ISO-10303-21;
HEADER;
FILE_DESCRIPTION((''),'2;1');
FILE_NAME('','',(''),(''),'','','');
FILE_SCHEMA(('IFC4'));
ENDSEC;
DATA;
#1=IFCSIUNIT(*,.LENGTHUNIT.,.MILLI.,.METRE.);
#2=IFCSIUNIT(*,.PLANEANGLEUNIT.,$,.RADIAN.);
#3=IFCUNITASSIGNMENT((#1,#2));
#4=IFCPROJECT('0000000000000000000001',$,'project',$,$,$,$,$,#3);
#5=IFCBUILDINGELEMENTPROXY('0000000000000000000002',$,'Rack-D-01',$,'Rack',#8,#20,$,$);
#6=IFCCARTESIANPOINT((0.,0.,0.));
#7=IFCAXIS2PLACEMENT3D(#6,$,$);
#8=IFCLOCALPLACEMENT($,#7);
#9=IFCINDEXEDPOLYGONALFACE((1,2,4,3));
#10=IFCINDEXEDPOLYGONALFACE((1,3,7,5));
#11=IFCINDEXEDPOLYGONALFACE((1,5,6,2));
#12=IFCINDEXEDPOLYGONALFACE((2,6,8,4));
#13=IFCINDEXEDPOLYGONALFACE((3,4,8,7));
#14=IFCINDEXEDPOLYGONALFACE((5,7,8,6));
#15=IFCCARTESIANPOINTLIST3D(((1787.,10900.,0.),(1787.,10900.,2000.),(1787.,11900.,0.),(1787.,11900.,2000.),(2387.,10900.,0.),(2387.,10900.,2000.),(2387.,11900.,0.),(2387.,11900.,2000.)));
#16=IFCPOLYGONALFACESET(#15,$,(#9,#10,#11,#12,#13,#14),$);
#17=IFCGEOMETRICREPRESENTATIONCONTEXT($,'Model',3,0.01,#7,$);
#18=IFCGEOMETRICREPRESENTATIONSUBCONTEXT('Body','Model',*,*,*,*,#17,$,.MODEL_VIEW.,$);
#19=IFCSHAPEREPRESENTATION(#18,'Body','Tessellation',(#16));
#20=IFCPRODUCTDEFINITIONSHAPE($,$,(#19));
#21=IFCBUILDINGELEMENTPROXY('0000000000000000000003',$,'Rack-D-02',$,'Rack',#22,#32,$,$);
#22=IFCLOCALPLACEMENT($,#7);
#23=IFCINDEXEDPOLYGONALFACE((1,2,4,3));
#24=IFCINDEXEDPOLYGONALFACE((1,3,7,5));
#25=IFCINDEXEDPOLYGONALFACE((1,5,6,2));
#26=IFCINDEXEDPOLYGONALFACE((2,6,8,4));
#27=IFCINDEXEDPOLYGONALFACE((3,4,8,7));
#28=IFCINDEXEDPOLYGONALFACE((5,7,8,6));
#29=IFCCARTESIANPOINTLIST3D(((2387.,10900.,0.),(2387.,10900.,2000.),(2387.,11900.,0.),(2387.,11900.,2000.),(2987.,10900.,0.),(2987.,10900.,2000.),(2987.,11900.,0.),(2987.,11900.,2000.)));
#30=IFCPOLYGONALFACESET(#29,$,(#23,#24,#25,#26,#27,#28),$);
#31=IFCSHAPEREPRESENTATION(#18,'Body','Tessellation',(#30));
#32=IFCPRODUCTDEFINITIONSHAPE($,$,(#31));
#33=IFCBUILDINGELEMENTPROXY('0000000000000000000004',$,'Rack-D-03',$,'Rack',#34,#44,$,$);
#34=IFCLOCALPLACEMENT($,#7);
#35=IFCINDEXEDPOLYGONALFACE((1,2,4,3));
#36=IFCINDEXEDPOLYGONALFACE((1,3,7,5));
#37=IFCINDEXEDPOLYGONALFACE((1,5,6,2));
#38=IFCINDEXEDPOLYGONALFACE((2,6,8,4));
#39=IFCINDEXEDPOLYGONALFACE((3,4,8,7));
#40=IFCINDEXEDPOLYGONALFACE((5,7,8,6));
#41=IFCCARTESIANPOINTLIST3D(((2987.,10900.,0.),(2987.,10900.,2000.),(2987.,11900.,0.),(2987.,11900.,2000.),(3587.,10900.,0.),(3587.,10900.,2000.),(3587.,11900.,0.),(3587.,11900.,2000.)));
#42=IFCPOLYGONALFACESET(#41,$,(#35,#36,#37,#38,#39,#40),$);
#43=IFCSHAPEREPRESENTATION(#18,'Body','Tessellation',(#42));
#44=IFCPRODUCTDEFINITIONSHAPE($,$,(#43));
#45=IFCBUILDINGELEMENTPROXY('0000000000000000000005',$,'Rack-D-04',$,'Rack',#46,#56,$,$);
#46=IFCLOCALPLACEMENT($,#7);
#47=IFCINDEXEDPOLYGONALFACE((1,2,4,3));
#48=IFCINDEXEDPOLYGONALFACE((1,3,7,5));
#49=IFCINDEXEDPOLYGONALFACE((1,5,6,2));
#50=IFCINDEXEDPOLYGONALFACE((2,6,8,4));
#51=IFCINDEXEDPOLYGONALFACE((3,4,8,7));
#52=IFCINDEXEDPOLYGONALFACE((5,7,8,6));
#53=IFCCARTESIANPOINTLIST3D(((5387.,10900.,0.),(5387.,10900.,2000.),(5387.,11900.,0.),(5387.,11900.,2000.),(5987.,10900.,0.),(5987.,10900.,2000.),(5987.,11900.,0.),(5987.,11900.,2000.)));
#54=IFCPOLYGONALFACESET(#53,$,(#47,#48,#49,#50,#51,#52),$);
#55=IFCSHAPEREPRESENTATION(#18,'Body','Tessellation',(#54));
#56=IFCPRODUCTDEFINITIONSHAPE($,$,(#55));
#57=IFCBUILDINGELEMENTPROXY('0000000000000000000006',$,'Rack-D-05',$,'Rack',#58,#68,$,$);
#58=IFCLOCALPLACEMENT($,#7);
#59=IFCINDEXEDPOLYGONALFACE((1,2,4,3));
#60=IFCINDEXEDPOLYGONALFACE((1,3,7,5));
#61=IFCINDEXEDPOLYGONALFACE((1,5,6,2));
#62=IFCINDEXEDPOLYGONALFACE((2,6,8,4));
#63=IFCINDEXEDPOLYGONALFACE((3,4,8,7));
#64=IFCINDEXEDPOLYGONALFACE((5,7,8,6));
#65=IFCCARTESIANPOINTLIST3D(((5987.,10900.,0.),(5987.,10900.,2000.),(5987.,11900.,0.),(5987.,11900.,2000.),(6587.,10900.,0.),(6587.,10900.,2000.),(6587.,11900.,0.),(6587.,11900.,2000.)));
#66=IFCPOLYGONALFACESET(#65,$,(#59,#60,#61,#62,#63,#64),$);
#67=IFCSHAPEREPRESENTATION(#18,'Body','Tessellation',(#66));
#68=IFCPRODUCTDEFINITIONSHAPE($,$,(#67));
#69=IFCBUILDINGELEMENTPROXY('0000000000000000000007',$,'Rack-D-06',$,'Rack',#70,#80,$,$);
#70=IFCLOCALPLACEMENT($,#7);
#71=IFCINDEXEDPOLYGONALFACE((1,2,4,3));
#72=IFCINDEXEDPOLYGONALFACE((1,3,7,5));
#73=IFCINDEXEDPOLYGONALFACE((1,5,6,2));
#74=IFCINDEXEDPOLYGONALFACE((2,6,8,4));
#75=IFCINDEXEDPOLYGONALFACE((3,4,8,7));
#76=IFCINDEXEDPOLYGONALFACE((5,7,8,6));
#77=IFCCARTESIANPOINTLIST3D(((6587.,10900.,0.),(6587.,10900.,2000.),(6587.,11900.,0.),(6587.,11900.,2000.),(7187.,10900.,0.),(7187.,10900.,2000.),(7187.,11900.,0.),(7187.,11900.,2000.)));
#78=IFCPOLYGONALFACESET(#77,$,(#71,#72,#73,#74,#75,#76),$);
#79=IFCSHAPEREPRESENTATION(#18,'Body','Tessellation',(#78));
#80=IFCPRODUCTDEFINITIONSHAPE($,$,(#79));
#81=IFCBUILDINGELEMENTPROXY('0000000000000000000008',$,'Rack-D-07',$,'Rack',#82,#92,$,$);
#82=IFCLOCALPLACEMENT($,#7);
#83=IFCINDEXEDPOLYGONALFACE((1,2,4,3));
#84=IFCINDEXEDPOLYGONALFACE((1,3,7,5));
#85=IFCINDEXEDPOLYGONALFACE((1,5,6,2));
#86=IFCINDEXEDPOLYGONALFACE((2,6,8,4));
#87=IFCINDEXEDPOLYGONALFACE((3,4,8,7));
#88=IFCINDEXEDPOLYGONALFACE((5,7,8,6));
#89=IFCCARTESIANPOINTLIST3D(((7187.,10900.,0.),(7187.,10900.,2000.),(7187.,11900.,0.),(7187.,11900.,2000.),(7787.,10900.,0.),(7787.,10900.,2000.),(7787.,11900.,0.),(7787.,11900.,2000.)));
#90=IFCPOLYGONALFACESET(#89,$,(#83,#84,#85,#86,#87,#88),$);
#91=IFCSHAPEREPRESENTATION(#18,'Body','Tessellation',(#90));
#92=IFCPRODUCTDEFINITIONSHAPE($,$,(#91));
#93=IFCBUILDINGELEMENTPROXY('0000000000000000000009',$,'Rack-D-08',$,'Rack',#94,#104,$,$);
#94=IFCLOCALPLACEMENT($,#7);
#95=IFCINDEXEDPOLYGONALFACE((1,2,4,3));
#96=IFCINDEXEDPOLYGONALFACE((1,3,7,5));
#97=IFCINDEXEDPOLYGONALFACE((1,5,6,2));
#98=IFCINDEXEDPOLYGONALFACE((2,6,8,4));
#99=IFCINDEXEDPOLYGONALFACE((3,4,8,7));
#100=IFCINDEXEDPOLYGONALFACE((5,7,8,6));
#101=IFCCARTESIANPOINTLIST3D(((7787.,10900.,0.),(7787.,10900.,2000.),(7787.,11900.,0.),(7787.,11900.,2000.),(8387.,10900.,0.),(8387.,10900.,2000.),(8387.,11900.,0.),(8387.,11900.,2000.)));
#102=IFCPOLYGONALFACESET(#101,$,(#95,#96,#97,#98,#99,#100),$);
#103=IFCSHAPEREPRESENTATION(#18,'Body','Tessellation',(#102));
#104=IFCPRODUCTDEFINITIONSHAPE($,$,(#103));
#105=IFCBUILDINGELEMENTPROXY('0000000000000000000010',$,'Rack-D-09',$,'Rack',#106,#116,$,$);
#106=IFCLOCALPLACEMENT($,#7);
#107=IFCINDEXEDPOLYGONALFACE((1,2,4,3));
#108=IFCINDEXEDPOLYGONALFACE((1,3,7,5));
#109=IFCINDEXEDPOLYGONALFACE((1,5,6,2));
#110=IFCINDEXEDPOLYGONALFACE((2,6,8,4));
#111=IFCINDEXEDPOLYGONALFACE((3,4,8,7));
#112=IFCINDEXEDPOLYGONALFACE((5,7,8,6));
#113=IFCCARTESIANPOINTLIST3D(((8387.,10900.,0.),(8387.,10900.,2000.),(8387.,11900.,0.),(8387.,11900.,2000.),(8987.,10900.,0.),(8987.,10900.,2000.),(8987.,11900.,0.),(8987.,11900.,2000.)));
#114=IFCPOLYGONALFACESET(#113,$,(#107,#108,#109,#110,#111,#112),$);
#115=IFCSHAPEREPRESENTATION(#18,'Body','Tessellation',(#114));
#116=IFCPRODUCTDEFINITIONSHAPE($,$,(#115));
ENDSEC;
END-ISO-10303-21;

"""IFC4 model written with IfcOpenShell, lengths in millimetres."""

from ifc_helpers import new_model, si_unit, frame, origin, place, context, subcontext, project, rectangle, extrude, element, save


model = new_model("IFC4")

# Units and contexts
model_context = context("Model", 3, precision=0.01, world=origin())
body_context = subcontext(model_context, "Body", "Model", "MODEL_VIEW")
ifc_project = project(units=[si_unit("LENGTHUNIT", "METRE", prefix="MILLI"), si_unit("PLANEANGLEUNIT", "RADIAN")])

# Shared definitions
placement = place(None, origin())

# Building element proxies
for number, where, name in (
    (1, (2087.0, 11400.0, 0.0), "Rack-D-01"),
    (2, (2687.0, 11400.0, 0.0), "Rack-D-02"),
    (3, (3287.0, 11400.0, 0.0), "Rack-D-03"),
    (4, (5687.0, 11400.0, 0.0), "Rack-D-04"),
    (5, (6287.0, 11400.0, 0.0), "Rack-D-05"),
    (6, (6887.0, 11400.0, 0.0), "Rack-D-06"),
    (7, (7487.0, 11400.0, 0.0), "Rack-D-07"),
    (8, (8087.0, 11400.0, 0.0), "Rack-D-08"),
    (9, (8687.0, 11400.0, 0.0), "Rack-D-09"),
):
    element("IfcBuildingElementProxy", number, at=place(placement, frame(where)), Name=name, ObjectType="Rack", context=body_context, shape_type="SweptSolid", body=[
        extrude(rectangle(XDim=600.0, YDim=1000.0), origin(), (0.0, 0.0, 1.0), 2000.0),
    ])

save(model, "model.ifc")
